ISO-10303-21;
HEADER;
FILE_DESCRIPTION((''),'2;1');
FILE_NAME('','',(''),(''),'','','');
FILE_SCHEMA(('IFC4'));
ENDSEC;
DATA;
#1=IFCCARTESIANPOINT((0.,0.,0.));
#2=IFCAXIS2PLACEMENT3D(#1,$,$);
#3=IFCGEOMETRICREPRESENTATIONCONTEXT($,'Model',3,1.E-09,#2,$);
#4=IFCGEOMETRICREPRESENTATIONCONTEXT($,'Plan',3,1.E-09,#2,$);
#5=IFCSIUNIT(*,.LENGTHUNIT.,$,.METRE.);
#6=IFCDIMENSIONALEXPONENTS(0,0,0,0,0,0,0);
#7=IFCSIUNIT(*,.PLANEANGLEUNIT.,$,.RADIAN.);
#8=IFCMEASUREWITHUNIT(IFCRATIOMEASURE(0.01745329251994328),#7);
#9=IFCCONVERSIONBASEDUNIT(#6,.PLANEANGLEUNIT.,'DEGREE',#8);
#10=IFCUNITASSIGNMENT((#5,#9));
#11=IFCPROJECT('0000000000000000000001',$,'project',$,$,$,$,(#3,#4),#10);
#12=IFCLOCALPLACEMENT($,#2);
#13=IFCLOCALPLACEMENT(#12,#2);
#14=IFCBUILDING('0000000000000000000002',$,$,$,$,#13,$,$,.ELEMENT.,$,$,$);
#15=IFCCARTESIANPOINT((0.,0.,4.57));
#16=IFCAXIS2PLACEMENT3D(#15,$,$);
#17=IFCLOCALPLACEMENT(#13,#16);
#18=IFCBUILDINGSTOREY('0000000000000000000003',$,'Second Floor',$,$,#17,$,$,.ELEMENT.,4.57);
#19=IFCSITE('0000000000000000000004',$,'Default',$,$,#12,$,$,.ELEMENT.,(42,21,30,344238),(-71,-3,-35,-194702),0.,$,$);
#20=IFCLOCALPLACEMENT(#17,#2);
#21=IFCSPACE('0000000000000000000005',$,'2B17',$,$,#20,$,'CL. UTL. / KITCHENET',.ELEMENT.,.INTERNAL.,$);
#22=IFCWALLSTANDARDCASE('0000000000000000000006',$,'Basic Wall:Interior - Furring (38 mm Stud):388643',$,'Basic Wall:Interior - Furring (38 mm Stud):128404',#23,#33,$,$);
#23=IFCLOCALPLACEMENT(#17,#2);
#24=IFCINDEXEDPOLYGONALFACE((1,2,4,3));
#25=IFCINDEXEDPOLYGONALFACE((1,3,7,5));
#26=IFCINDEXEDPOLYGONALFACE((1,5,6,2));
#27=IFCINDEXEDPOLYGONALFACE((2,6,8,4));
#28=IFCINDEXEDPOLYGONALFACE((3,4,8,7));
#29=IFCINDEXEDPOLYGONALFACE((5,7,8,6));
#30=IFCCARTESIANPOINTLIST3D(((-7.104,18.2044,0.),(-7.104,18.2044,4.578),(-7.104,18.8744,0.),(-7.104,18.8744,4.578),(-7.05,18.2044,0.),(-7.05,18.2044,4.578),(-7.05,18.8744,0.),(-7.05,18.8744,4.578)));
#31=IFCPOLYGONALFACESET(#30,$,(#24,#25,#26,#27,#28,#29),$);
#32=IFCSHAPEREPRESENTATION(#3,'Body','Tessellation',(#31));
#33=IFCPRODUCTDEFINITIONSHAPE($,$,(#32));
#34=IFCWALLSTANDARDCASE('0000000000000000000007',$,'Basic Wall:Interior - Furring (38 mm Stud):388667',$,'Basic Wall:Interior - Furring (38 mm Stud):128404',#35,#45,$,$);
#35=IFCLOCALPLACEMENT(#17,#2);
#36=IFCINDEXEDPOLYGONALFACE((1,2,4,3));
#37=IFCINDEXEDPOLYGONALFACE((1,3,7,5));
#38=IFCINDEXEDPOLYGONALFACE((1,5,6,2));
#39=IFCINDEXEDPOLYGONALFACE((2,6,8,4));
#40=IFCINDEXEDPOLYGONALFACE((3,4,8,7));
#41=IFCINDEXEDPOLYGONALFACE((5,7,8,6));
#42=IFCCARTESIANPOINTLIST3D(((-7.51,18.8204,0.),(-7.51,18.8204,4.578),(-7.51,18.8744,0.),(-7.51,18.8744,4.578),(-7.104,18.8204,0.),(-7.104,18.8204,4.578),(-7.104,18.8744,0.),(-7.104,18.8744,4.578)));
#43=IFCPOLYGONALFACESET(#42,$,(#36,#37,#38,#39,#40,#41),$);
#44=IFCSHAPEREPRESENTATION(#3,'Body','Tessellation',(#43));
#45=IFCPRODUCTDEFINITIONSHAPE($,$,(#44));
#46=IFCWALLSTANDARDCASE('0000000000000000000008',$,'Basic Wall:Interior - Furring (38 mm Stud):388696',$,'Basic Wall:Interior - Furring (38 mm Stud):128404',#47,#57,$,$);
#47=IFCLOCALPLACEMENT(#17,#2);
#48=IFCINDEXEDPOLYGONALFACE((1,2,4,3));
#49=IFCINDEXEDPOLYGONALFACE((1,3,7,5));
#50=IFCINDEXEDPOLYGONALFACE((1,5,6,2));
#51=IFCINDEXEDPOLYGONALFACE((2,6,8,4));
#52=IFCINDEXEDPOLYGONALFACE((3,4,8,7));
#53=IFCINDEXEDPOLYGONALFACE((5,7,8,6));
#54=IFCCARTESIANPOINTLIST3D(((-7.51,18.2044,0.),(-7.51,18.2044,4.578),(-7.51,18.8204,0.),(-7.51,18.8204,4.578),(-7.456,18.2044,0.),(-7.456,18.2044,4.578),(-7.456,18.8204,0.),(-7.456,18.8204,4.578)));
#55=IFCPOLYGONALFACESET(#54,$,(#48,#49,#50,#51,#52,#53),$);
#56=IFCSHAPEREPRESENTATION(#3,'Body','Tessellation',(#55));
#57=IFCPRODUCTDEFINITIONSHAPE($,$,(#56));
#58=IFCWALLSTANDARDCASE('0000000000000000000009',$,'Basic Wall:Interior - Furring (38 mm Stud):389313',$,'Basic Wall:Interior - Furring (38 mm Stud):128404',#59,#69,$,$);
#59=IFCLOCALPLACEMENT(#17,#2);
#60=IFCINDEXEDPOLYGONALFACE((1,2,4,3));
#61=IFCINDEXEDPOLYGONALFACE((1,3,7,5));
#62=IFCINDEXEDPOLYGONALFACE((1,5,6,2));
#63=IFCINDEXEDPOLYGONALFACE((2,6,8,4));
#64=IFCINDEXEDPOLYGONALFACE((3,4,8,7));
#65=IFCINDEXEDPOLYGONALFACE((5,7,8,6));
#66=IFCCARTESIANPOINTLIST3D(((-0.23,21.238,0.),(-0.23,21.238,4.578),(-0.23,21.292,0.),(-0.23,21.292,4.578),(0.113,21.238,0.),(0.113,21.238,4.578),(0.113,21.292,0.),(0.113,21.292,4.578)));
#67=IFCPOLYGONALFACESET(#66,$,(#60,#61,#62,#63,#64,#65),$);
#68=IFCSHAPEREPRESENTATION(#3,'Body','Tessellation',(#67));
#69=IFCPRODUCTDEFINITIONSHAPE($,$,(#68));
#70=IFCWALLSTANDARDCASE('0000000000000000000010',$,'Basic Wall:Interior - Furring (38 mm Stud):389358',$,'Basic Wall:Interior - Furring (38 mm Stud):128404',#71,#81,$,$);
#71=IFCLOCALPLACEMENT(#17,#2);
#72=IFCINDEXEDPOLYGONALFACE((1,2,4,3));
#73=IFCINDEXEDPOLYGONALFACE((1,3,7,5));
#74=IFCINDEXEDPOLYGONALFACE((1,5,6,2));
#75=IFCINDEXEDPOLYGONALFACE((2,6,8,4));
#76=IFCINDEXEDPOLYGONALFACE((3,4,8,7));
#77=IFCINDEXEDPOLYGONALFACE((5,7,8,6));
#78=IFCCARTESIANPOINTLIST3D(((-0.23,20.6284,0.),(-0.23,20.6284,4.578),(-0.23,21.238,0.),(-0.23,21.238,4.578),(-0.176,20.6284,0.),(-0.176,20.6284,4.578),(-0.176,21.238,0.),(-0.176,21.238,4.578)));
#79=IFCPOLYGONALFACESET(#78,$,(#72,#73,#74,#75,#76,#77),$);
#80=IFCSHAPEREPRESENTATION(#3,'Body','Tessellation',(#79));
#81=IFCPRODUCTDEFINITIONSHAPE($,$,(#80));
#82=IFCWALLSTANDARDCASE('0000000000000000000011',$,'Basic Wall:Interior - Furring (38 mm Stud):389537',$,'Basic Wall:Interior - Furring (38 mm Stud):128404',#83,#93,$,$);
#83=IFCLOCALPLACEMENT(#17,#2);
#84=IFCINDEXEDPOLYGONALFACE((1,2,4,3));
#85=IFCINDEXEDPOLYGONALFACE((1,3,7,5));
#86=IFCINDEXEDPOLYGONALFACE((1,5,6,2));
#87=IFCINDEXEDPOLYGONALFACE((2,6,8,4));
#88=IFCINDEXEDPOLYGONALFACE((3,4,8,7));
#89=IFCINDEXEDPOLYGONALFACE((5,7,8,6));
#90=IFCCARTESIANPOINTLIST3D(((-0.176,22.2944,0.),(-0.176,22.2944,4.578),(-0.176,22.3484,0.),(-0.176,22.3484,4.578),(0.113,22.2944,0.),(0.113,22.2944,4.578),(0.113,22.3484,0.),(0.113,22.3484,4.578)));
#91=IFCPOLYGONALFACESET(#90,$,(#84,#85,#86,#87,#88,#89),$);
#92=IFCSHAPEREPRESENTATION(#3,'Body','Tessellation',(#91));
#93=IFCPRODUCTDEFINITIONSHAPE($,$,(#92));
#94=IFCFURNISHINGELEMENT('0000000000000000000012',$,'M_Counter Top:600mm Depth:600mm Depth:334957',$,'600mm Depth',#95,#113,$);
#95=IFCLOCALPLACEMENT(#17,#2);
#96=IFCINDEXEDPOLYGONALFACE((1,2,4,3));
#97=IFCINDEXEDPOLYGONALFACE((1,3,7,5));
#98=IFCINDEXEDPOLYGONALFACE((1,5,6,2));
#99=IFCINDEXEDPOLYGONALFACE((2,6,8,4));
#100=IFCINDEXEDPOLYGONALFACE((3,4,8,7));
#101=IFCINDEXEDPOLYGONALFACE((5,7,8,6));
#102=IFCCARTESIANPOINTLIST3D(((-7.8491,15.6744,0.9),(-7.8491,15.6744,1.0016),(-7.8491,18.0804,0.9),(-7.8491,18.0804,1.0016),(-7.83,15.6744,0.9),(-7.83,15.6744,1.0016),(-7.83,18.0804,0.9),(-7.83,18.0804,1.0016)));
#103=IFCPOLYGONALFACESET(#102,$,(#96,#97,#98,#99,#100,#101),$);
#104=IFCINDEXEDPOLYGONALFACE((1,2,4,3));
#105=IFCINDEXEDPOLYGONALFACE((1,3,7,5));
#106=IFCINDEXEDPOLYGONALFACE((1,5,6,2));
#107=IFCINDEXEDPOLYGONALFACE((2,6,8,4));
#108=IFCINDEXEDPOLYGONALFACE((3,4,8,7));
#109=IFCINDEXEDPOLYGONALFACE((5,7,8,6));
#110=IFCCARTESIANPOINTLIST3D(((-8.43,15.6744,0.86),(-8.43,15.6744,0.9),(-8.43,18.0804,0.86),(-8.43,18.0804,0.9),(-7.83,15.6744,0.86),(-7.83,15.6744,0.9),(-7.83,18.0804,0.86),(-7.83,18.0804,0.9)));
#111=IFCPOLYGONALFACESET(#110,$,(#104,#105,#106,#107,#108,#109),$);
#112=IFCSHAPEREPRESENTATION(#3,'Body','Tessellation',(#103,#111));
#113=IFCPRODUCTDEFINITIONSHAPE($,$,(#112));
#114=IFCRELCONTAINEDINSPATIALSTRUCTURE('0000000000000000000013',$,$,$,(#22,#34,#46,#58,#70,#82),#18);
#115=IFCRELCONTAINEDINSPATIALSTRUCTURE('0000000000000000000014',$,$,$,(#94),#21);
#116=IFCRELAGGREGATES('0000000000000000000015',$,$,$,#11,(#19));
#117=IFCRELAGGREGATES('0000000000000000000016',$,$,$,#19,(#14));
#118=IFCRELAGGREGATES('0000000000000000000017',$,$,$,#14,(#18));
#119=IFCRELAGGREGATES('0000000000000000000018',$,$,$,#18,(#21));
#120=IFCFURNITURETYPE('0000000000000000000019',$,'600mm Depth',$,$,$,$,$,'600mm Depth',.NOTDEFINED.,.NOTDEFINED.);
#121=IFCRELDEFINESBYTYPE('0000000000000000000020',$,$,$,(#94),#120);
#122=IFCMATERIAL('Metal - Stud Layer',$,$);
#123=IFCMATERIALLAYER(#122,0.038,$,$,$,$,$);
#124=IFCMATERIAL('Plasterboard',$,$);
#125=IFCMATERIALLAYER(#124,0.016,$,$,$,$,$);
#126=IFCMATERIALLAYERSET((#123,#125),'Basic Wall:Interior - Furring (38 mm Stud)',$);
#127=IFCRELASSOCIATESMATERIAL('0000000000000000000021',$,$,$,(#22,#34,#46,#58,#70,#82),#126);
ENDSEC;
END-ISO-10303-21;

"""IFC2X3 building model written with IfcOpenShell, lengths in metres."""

from ifc_helpers import new_model, entity, si_unit, converted_unit, frame, frame_2d, origin, origin_2d_with_axis, place, context, project, spatial, rectangle, extrude, source, transform, mapped, material, layer, layer_set, layer_usage, type_object, type_shapes, element, save


model = new_model("IFC2X3")

# Units and contexts
model_context = context("Model", 3, precision=1e-09, world=origin())
plan_context = context("Plan", 3, precision=1e-09, world=origin())
ifc_project = project(units=[si_unit("LENGTHUNIT", "METRE"), converted_unit("PLANEANGLEUNIT", "DEGREE", entity("IfcRatioMeasure", 0.01745329251994328), si_unit("PLANEANGLEUNIT", "RADIAN"), dimensions=[0, 0, 0, 0, 0, 0, 0])], contexts=[model_context, plan_context])

# Site, building, storey
site_placement = place(None, origin())
site = spatial("IfcSite", under=ifc_project, at=site_placement, Name="Default", CompositionType="ELEMENT", RefLatitude=(42, 21, 30, 344238), RefLongitude=(-71, -3, -35, -194702), RefElevation=0.0)
building_placement = place(site_placement, origin())
building = spatial("IfcBuilding", under=site, at=building_placement, CompositionType="ELEMENT")
storey_placement = place(building_placement, frame((0.0, 0.0, 4.57)))
storey = spatial("IfcBuildingStorey", under=building, at=storey_placement, Name="Second Floor", CompositionType="ELEMENT", Elevation=4.57)

# Shared definitions
ifc_material_1 = material(Name="Plasterboard")
ifc_layer_1 = layer(ifc_material_1, 0.016)
ifc_material_2 = material(Name="Metal - Stud Layer")

# Shared definitions
ifc_layer_2 = layer(ifc_material_2, 0.038)
ifc_layer_set_1 = layer_set([ifc_layer_2, ifc_layer_1], Name="Basic Wall:Interior - Furring (38 mm Stud)")
ifc_layer_usage_1 = layer_usage(ifc_layer_set_1, "AXIS2", "NEGATIVE", 0.027)

# Walls
wall_1_placement = place(storey_placement, frame((-7.077, 18.2044, 0.0), z_axis=(0.0, 0.0, 1.0), x_axis=(0.0, 1.0, 0.0)))
element("IfcWallStandardCase", 1, at=wall_1_placement, inside=storey, material=ifc_layer_usage_1, Name="Basic Wall:Interior - Furring (38 mm Stud):388643", ObjectType="Basic Wall:Interior - Furring (38 mm Stud):128404", context=model_context, shape_type="SweptSolid", body=[
    extrude(rectangle(XDim=0.67, YDim=0.054, at=frame_2d((0.335, 0.0), x_axis=(-1.0, 0.0))), origin(), (0.0, 0.0, 1.0), 4.578),
])
wall_2_placement = place(storey_placement, frame((-7.104, 18.8474, 0.0), z_axis=(0.0, 0.0, 1.0), x_axis=(-1.0, 0.0, 0.0)))
element("IfcWallStandardCase", 2, at=wall_2_placement, inside=storey, material=ifc_layer_usage_1, Name="Basic Wall:Interior - Furring (38 mm Stud):388667", ObjectType="Basic Wall:Interior - Furring (38 mm Stud):128404", context=model_context, shape_type="SweptSolid", body=[
    extrude(rectangle(XDim=0.406, YDim=0.054, at=frame_2d((0.203, 0.0), x_axis=(-1.0, 0.0))), origin(), (0.0, 0.0, 1.0), 4.578),
])
wall_3_placement = place(storey_placement, frame((-7.483, 18.8204, 0.0), z_axis=(0.0, 0.0, 1.0), x_axis=(0.0, -1.0, 0.0)))
element("IfcWallStandardCase", 3, at=wall_3_placement, inside=storey, material=ifc_layer_usage_1, Name="Basic Wall:Interior - Furring (38 mm Stud):388696", ObjectType="Basic Wall:Interior - Furring (38 mm Stud):128404", context=model_context, shape_type="SweptSolid", body=[
    extrude(rectangle(XDim=0.616, YDim=0.054, at=frame_2d((0.308, 0.0), x_axis=(-1.0, 0.0))), origin(), (0.0, 0.0, 1.0), 4.578),
])
wall_4_placement = place(storey_placement, frame((0.113, 21.265, 0.0), z_axis=(0.0, 0.0, 1.0), x_axis=(-1.0, 0.0, 0.0)))
element("IfcWallStandardCase", 4, at=wall_4_placement, inside=storey, material=ifc_layer_usage_1, Name="Basic Wall:Interior - Furring (38 mm Stud):389313", ObjectType="Basic Wall:Interior - Furring (38 mm Stud):128404", context=model_context, shape_type="SweptSolid", body=[
    extrude(rectangle(XDim=0.343, YDim=0.054, at=frame_2d((0.1715, 0.0), x_axis=(-1.0, 0.0))), origin(), (0.0, 0.0, 1.0), 4.578),
])
wall_5_placement = place(storey_placement, frame((-0.203, 21.238, 0.0), z_axis=(0.0, 0.0, 1.0), x_axis=(0.0, -1.0, 0.0)))
element("IfcWallStandardCase", 5, at=wall_5_placement, inside=storey, material=ifc_layer_usage_1, Name="Basic Wall:Interior - Furring (38 mm Stud):389358", ObjectType="Basic Wall:Interior - Furring (38 mm Stud):128404", context=model_context, shape_type="SweptSolid", body=[
    extrude(rectangle(XDim=0.6096, YDim=0.054, at=frame_2d((0.3048, 0.0), x_axis=(-1.0, 0.0))), origin(), (0.0, 0.0, 1.0), 4.578),
])
wall_6_placement = place(storey_placement, frame((-0.176, 22.3214, 0.0)))
element("IfcWallStandardCase", 6, at=wall_6_placement, inside=storey, material=ifc_layer_usage_1, Name="Basic Wall:Interior - Furring (38 mm Stud):389537", ObjectType="Basic Wall:Interior - Furring (38 mm Stud):128404", context=model_context, shape_type="SweptSolid", body=[
    extrude(rectangle(XDim=0.289, YDim=0.054, at=frame_2d((0.1445, 0.0), x_axis=(-1.0, 0.0))), origin(), (0.0, 0.0, 1.0), 4.578),
])

# Shared definitions
space_1_placement = place(storey_placement, origin())
space_1 = spatial("IfcSpace", under=storey, at=space_1_placement, Name="2B17", LongName="CL. UTL. / KITCHENET", CompositionType="ELEMENT", InteriorOrExteriorSpace="INTERNAL")

# Furnishing element
furniture_type = type_object("IfcFurnitureType", Name="600mm Depth", ElementType="600mm Depth", AssemblyPlace="NOTDEFINED")
shared_shape_1 = source(origin(), model_context, "Body", "SweptSolid", [
    extrude(rectangle(XDim=0.0191, YDim=2.406, at=origin_2d_with_axis()), frame((0.0025, -0.0095, 0.9), z_axis=(0.0, 0.0, 1.0), x_axis=(0.0, -1.0, 0.0)), (0.0, 0.0, 1.0), 0.1016),
    extrude(rectangle(XDim=2.406, YDim=0.6, at=origin_2d_with_axis()), frame((0.0025, -0.3, 0.86), z_axis=(0.0, 0.0, 1.0), x_axis=(-1.0, 0.0, 0.0)), (0.0, 0.0, 1.0), 0.04),
])
type_shapes(furniture_type, [shared_shape_1])
furnishing_placement = place(space_1_placement, frame((-7.83, 16.88, 0.0), z_axis=(0.0, 0.0, 1.0), x_axis=(0.0, -1.0, 0.0)))
element("IfcFurnishingElement", 7, at=furnishing_placement, inside=space_1, type_object=furniture_type, Name="M_Counter Top:600mm Depth:600mm Depth:334957", ObjectType="600mm Depth", context=model_context, shape_type="MappedRepresentation", body=[
    mapped(shared_shape_1, transform((0.0, 0.0, 0.0), scale=1.0)),
])

save(model, "model.ifc")
